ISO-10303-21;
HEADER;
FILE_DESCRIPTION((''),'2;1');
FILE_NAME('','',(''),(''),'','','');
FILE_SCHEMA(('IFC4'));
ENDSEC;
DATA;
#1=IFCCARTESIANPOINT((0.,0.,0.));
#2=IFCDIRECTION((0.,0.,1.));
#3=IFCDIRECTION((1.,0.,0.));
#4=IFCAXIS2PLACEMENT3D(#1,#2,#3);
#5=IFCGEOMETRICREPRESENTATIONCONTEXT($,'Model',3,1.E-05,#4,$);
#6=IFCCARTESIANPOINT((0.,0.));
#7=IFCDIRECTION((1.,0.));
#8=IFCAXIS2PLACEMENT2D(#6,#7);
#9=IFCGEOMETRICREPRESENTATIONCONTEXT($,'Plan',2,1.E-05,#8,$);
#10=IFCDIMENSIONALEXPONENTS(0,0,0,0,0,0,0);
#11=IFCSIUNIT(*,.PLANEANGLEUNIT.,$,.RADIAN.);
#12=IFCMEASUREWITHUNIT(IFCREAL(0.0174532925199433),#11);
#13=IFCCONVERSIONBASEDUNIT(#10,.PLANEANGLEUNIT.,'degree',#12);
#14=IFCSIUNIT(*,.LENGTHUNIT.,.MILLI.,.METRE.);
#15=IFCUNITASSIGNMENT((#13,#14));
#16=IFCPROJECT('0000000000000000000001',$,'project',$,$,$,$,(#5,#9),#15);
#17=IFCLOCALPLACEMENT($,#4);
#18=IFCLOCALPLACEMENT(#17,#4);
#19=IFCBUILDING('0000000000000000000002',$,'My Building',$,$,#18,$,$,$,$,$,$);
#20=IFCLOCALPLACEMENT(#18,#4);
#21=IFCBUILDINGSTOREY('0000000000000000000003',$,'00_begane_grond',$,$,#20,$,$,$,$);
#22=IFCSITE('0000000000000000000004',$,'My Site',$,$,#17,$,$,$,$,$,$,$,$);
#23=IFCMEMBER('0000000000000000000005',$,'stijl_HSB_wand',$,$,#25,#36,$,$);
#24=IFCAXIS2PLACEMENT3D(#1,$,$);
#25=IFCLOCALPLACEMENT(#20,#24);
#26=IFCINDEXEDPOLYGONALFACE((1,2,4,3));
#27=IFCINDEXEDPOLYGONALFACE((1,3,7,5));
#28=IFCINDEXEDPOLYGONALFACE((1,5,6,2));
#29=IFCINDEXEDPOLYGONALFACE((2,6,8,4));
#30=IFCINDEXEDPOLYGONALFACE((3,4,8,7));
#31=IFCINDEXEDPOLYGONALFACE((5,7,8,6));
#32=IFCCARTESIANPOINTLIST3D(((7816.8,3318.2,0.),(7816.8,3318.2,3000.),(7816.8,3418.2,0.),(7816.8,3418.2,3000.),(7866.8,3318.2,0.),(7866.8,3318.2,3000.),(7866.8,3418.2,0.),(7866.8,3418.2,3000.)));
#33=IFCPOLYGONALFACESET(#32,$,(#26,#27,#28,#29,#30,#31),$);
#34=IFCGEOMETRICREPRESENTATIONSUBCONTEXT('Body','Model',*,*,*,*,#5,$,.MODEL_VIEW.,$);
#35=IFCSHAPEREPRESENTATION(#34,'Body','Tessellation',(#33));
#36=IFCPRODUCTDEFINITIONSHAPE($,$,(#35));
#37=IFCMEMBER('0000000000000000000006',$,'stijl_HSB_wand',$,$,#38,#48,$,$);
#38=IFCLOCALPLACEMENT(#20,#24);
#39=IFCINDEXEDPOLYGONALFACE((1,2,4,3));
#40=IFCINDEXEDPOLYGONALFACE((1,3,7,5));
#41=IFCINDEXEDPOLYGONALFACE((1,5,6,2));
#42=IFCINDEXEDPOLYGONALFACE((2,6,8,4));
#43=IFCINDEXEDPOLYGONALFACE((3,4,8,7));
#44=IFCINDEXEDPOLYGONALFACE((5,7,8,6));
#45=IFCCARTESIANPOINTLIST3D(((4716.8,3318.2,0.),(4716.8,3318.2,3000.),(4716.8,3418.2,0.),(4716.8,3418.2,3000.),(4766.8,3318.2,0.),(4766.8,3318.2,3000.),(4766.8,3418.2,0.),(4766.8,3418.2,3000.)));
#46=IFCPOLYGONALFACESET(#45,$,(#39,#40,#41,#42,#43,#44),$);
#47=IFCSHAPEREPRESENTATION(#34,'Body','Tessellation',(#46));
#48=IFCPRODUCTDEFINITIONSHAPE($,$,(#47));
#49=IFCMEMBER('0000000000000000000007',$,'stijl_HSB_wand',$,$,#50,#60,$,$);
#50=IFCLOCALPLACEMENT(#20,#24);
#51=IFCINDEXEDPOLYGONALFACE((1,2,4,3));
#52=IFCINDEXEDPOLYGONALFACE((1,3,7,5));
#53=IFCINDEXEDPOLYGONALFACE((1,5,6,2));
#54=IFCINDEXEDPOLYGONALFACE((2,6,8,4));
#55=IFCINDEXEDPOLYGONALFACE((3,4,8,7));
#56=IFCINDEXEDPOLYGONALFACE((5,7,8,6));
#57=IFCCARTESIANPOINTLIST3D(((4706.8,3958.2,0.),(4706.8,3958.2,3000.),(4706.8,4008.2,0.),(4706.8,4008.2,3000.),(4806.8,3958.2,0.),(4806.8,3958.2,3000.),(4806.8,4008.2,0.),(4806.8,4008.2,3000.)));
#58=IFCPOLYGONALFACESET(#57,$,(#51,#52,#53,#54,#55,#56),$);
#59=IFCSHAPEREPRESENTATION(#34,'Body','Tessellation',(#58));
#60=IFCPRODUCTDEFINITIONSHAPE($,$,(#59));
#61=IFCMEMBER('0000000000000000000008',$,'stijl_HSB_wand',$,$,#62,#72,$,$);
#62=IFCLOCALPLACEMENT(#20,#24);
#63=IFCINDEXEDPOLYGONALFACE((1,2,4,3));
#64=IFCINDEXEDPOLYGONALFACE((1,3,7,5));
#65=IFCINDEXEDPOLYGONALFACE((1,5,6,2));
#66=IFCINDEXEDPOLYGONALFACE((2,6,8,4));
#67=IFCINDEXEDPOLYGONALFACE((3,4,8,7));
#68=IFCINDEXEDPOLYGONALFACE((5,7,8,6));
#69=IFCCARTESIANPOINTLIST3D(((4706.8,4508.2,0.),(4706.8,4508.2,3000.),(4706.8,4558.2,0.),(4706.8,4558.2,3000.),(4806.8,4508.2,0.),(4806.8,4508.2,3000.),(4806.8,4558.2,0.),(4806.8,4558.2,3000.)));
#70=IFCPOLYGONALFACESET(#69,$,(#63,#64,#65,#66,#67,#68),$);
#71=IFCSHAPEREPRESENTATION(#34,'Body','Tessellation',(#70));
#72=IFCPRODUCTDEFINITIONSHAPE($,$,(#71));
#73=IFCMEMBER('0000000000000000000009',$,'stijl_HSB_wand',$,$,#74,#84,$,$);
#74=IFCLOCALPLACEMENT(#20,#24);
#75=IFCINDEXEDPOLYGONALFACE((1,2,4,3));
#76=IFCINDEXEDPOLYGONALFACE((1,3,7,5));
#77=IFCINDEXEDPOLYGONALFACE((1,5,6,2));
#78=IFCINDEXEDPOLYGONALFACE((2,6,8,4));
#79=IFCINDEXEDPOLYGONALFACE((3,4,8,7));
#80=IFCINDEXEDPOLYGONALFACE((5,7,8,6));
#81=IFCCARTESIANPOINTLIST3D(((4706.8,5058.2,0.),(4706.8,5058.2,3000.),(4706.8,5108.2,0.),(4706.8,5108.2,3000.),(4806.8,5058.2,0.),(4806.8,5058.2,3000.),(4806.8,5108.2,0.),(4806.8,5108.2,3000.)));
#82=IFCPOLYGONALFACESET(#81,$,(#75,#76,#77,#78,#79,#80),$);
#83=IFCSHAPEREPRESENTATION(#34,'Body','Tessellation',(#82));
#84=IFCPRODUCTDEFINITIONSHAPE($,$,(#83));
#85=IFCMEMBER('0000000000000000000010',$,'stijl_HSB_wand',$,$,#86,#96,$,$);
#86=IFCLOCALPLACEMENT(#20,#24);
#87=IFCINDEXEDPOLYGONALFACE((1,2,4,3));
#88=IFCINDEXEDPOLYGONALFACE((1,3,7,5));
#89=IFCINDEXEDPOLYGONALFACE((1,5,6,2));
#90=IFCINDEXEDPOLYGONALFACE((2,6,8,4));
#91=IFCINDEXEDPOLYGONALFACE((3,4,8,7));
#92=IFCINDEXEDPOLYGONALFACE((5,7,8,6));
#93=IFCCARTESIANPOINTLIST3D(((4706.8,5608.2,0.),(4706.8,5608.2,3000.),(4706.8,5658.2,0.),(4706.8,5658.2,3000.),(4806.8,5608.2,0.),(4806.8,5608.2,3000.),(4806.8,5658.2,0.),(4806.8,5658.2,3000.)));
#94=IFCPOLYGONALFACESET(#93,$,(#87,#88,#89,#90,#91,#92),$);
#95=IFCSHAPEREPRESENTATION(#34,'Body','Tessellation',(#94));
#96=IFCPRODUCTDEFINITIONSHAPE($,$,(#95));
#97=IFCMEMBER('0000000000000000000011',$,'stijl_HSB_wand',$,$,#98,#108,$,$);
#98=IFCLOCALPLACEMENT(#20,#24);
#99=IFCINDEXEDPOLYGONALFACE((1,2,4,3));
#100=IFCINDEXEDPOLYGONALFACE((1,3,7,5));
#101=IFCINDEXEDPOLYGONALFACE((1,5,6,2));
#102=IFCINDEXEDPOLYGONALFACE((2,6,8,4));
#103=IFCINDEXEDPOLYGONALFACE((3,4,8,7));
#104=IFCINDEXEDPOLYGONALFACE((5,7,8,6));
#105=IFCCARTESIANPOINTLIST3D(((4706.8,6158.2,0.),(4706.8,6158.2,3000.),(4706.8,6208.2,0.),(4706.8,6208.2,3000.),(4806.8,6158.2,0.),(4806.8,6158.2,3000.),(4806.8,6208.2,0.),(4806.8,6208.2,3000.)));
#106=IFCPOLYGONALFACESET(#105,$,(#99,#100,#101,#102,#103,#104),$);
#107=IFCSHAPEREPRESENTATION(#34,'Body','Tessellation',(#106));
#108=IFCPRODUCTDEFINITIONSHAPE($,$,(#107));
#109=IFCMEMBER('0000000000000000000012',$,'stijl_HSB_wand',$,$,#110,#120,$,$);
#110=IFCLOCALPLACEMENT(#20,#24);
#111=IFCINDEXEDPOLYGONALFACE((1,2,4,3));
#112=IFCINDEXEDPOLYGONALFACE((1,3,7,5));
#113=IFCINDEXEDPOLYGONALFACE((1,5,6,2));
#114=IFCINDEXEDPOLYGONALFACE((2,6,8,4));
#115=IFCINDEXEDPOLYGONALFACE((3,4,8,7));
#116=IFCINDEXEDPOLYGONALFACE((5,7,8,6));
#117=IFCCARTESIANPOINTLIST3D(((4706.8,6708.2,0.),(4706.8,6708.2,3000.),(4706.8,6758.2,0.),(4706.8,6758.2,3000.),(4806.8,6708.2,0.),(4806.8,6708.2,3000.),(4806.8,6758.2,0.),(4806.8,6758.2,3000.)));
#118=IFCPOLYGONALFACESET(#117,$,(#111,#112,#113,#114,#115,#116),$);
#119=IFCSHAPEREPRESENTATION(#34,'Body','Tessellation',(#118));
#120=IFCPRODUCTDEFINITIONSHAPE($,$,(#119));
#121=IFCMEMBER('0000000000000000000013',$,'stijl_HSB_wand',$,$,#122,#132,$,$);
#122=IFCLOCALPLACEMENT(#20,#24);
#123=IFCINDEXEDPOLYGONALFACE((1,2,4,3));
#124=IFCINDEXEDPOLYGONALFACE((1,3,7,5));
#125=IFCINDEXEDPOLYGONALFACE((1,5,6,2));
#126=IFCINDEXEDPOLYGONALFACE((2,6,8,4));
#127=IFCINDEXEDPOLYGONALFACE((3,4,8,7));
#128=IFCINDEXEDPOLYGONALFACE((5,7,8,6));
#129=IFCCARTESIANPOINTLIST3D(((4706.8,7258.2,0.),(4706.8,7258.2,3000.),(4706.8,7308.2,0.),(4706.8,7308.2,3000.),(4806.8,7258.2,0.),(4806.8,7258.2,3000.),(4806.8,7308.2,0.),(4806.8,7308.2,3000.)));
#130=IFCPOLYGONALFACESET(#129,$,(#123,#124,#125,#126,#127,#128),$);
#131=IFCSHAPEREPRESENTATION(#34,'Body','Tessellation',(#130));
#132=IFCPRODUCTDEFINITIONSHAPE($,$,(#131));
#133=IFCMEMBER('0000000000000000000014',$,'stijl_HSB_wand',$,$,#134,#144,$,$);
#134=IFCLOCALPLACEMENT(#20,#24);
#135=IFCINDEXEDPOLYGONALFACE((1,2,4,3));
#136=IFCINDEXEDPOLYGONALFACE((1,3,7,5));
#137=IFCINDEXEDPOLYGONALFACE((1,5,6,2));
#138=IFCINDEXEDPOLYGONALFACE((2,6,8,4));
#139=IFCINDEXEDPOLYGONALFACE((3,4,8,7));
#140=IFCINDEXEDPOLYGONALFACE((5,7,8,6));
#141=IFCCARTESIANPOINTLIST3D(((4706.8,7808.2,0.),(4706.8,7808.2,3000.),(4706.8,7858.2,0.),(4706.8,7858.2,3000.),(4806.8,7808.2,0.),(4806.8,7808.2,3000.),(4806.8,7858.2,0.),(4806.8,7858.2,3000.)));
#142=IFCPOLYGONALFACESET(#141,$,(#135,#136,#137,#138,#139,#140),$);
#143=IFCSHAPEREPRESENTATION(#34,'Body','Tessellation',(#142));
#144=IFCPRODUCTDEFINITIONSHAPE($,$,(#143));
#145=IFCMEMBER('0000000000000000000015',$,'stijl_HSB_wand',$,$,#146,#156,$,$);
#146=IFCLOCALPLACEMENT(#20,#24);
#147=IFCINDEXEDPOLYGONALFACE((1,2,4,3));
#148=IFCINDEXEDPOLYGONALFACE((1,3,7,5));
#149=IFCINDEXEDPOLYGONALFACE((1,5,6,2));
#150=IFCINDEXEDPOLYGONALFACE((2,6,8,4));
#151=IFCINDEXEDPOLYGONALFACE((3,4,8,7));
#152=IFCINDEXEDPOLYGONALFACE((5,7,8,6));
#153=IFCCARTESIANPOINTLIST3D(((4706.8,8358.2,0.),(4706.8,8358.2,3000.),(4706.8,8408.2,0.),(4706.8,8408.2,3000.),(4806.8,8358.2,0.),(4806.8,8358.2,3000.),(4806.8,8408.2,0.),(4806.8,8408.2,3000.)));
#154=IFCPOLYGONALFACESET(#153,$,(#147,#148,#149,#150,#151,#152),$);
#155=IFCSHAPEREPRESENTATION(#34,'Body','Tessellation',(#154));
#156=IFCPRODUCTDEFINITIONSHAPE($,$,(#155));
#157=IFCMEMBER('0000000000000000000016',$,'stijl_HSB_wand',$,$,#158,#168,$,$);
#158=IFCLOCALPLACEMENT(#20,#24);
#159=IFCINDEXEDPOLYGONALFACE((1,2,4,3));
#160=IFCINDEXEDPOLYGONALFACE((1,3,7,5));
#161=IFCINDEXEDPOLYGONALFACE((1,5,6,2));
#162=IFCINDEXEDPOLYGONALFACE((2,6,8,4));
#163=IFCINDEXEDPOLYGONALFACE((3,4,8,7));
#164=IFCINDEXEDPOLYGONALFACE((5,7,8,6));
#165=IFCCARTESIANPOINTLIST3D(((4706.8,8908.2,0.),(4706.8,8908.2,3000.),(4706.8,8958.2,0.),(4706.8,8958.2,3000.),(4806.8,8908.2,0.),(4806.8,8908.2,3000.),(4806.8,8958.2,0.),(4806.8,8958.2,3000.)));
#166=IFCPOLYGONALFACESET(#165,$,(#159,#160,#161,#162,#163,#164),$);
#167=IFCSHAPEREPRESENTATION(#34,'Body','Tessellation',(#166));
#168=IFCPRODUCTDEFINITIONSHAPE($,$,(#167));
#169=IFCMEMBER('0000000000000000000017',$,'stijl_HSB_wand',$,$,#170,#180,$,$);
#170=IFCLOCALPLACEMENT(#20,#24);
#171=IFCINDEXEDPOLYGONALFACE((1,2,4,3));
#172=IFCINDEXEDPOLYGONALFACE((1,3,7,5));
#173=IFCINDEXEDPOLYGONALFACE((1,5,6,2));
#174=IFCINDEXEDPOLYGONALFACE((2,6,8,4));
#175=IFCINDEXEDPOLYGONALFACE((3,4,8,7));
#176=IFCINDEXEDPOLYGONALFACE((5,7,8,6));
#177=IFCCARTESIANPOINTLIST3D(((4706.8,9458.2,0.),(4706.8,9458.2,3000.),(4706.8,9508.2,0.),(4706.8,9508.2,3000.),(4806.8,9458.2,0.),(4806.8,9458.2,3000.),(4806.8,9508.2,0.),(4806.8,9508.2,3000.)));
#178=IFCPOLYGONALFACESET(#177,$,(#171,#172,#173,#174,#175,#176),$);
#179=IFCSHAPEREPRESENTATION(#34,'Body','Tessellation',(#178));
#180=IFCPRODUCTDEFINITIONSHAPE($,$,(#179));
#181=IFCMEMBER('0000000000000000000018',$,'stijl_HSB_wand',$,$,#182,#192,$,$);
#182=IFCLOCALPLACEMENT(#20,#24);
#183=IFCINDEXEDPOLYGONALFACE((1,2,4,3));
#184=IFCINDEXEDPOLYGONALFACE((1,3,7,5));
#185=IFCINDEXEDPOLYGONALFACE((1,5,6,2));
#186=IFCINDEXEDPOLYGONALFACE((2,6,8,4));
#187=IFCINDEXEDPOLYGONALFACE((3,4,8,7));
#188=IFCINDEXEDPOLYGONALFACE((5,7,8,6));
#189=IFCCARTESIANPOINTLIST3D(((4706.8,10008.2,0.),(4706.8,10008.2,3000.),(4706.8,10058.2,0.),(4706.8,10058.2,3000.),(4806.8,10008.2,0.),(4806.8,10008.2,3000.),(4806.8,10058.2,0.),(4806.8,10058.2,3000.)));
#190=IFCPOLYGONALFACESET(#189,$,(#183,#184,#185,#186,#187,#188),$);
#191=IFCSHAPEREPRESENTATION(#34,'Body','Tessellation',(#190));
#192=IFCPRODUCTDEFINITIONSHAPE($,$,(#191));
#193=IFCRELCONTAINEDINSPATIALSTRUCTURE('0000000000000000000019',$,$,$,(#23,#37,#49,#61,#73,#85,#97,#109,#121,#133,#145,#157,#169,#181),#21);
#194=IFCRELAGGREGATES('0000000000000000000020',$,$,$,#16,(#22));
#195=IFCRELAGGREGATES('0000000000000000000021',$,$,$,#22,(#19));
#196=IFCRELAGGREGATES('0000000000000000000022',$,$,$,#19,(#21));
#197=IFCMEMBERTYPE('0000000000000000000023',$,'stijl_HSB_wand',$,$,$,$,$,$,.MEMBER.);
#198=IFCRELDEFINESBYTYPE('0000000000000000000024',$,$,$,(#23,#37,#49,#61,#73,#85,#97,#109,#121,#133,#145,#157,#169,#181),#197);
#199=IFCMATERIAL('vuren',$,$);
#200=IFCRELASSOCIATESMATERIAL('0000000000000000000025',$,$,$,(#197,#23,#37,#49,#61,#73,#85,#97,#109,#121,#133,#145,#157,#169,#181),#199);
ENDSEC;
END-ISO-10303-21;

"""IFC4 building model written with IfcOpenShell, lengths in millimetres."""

from ifc_helpers import new_model, entity, si_unit, converted_unit, frame, origin_with_axes, origin_2d_with_axis, place, context, subcontext, project, spatial, rectangle, extrude, material, material_profile, profile_set, profile_usage, type_object, element, save


model = new_model("IFC4")

# Units and contexts
model_context = context("Model", 3, precision=1e-05, world=origin_with_axes())
plan_context = context("Plan", 2, precision=1e-05, world=origin_2d_with_axis())
body_context = subcontext(model_context, "Body", "Model", "MODEL_VIEW")
ifc_project = project(units=[converted_unit("PLANEANGLEUNIT", "degree", entity("IfcReal", 0.0174532925199433), si_unit("PLANEANGLEUNIT", "RADIAN"), dimensions=[0, 0, 0, 0, 0, 0, 0]), si_unit("LENGTHUNIT", "METRE", prefix="MILLI")], contexts=[model_context, plan_context])

# Site, building, storey
site_placement = place(None, origin_with_axes())
site = spatial("IfcSite", under=ifc_project, at=site_placement, Name="My Site")
building_placement = place(site_placement, origin_with_axes())
building = spatial("IfcBuilding", under=site, at=building_placement, Name="My Building")
storey_placement = place(building_placement, origin_with_axes())
storey = spatial("IfcBuildingStorey", under=building, at=storey_placement, Name="00_begane_grond")

# Members
ifc_material_1 = material(Name="vuren")
ifc_material_profile_1 = material_profile(ifc_material_1, rectangle(XDim=100.0, YDim=50.0))
ifc_material_profile_2 = material_profile(ifc_material_1, rectangle(XDim=100.0, YDim=50.0))
ifc_profile_set_1 = profile_set([ifc_material_profile_1, ifc_material_profile_2])
ifc_profile_usage_1 = profile_usage(ifc_profile_set_1, cardinal=1)
member_type_1 = type_object("IfcMemberType", Name="stijl_HSB_wand", PredefinedType="MEMBER", material=ifc_profile_set_1)
member_1_placement = place(storey_placement, frame((7866.8, 3418.2, 0.0), z_axis=(0.0, 0.0, 1.0), x_axis=(0.0, 1.0, 0.0)))
element("IfcMember", 1, at=member_1_placement, inside=storey, type_object=member_type_1, material=ifc_profile_usage_1, Name="stijl_HSB_wand", context=body_context, shape_type="SweptSolid", body=[
    extrude(rectangle(XDim=100.0, YDim=50.0), frame((-50.0, 25.0, 0.0), z_axis=(0.0, 0.0, 1.0), x_axis=(1.0, 0.0, 0.0)), (0.0, 0.0, 1.0), 3000.0),
])
ifc_profile_usage_2 = profile_usage(ifc_profile_set_1, cardinal=1)
member_2_placement = place(storey_placement, frame((4766.8, 3418.2, 0.0), z_axis=(0.0, 0.0, 1.0), x_axis=(0.0, 1.0, 0.0)))
element("IfcMember", 2, at=member_2_placement, inside=storey, type_object=member_type_1, material=ifc_profile_usage_2, Name="stijl_HSB_wand", context=body_context, shape_type="SweptSolid", body=[
    extrude(rectangle(XDim=100.0, YDim=50.0), frame((-50.0, 25.0, 0.0), z_axis=(0.0, 0.0, 1.0), x_axis=(1.0, 0.0, 0.0)), (0.0, 0.0, 1.0), 3000.0),
])
ifc_profile_usage_3 = profile_usage(ifc_profile_set_1, cardinal=1)
member_3_placement = place(storey_placement, frame((4806.8, 3958.2, 0.0), z_axis=(0.0, 0.0, 1.0), x_axis=(1.0, 0.0, 0.0)))
element("IfcMember", 3, at=member_3_placement, inside=storey, type_object=member_type_1, material=ifc_profile_usage_3, Name="stijl_HSB_wand", context=body_context, shape_type="SweptSolid", body=[
    extrude(rectangle(XDim=100.0, YDim=50.0), frame((-50.0, 25.0, 0.0), z_axis=(0.0, 0.0, 1.0), x_axis=(1.0, 0.0, 0.0)), (0.0, 0.0, 1.0), 3000.0),
])
ifc_profile_usage_4 = profile_usage(ifc_profile_set_1, cardinal=1)
member_4_placement = place(storey_placement, frame((4806.8, 4508.2, 0.0), z_axis=(0.0, 0.0, 1.0), x_axis=(1.0, 0.0, 0.0)))
element("IfcMember", 4, at=member_4_placement, inside=storey, type_object=member_type_1, material=ifc_profile_usage_4, Name="stijl_HSB_wand", context=body_context, shape_type="SweptSolid", body=[
    extrude(rectangle(XDim=100.0, YDim=50.0), frame((-50.0, 25.0, 0.0), z_axis=(0.0, 0.0, 1.0), x_axis=(1.0, 0.0, 0.0)), (0.0, 0.0, 1.0), 3000.0),
])
ifc_profile_usage_5 = profile_usage(ifc_profile_set_1, cardinal=1)
member_5_placement = place(storey_placement, frame((4806.8, 5058.2, 0.0), z_axis=(0.0, 0.0, 1.0), x_axis=(1.0, 0.0, 0.0)))
element("IfcMember", 5, at=member_5_placement, inside=storey, type_object=member_type_1, material=ifc_profile_usage_5, Name="stijl_HSB_wand", context=body_context, shape_type="SweptSolid", body=[
    extrude(rectangle(XDim=100.0, YDim=50.0), frame((-50.0, 25.0, 0.0), z_axis=(0.0, 0.0, 1.0), x_axis=(1.0, 0.0, 0.0)), (0.0, 0.0, 1.0), 3000.0),
])
ifc_profile_usage_6 = profile_usage(ifc_profile_set_1, cardinal=1)
member_6_placement = place(storey_placement, frame((4806.8, 5608.2, 0.0), z_axis=(0.0, 0.0, 1.0), x_axis=(1.0, 0.0, 0.0)))
element("IfcMember", 6, at=member_6_placement, inside=storey, type_object=member_type_1, material=ifc_profile_usage_6, Name="stijl_HSB_wand", context=body_context, shape_type="SweptSolid", body=[
    extrude(rectangle(XDim=100.0, YDim=50.0), frame((-50.0, 25.0, 0.0), z_axis=(0.0, 0.0, 1.0), x_axis=(1.0, 0.0, 0.0)), (0.0, 0.0, 1.0), 3000.0),
])
ifc_profile_usage_7 = profile_usage(ifc_profile_set_1, cardinal=1)
member_7_placement = place(storey_placement, frame((4806.8, 6158.2, 0.0), z_axis=(0.0, 0.0, 1.0), x_axis=(1.0, 0.0, 0.0)))
element("IfcMember", 7, at=member_7_placement, inside=storey, type_object=member_type_1, material=ifc_profile_usage_7, Name="stijl_HSB_wand", context=body_context, shape_type="SweptSolid", body=[
    extrude(rectangle(XDim=100.0, YDim=50.0), frame((-50.0, 25.0, 0.0), z_axis=(0.0, 0.0, 1.0), x_axis=(1.0, 0.0, 0.0)), (0.0, 0.0, 1.0), 3000.0),
])
ifc_profile_usage_8 = profile_usage(ifc_profile_set_1, cardinal=1)
member_8_placement = place(storey_placement, frame((4806.8, 6708.2, 0.0), z_axis=(0.0, 0.0, 1.0), x_axis=(1.0, 0.0, 0.0)))
element("IfcMember", 8, at=member_8_placement, inside=storey, type_object=member_type_1, material=ifc_profile_usage_8, Name="stijl_HSB_wand", context=body_context, shape_type="SweptSolid", body=[
    extrude(rectangle(XDim=100.0, YDim=50.0), frame((-50.0, 25.0, 0.0), z_axis=(0.0, 0.0, 1.0), x_axis=(1.0, 0.0, 0.0)), (0.0, 0.0, 1.0), 3000.0),
])
ifc_profile_usage_9 = profile_usage(ifc_profile_set_1, cardinal=1)
member_9_placement = place(storey_placement, frame((4806.8, 7258.2, 0.0), z_axis=(0.0, 0.0, 1.0), x_axis=(1.0, 0.0, 0.0)))
element("IfcMember", 9, at=member_9_placement, inside=storey, type_object=member_type_1, material=ifc_profile_usage_9, Name="stijl_HSB_wand", context=body_context, shape_type="SweptSolid", body=[
    extrude(rectangle(XDim=100.0, YDim=50.0), frame((-50.0, 25.0, 0.0), z_axis=(0.0, 0.0, 1.0), x_axis=(1.0, 0.0, 0.0)), (0.0, 0.0, 1.0), 3000.0),
])
ifc_profile_usage_10 = profile_usage(ifc_profile_set_1, cardinal=1)
member_10_placement = place(storey_placement, frame((4806.8, 7808.2, 0.0), z_axis=(0.0, 0.0, 1.0), x_axis=(1.0, 0.0, 0.0)))
element("IfcMember", 10, at=member_10_placement, inside=storey, type_object=member_type_1, material=ifc_profile_usage_10, Name="stijl_HSB_wand", context=body_context, shape_type="SweptSolid", body=[
    extrude(rectangle(XDim=100.0, YDim=50.0), frame((-50.0, 25.0, 0.0), z_axis=(0.0, 0.0, 1.0), x_axis=(1.0, 0.0, 0.0)), (0.0, 0.0, 1.0), 3000.0),
])
ifc_profile_usage_11 = profile_usage(ifc_profile_set_1, cardinal=1)
member_11_placement = place(storey_placement, frame((4806.8, 8358.2, 0.0), z_axis=(0.0, 0.0, 1.0), x_axis=(1.0, 0.0, 0.0)))
element("IfcMember", 11, at=member_11_placement, inside=storey, type_object=member_type_1, material=ifc_profile_usage_11, Name="stijl_HSB_wand", context=body_context, shape_type="SweptSolid", body=[
    extrude(rectangle(XDim=100.0, YDim=50.0), frame((-50.0, 25.0, 0.0), z_axis=(0.0, 0.0, 1.0), x_axis=(1.0, 0.0, 0.0)), (0.0, 0.0, 1.0), 3000.0),
])
ifc_profile_usage_12 = profile_usage(ifc_profile_set_1, cardinal=1)
member_12_placement = place(storey_placement, frame((4806.8, 8908.2, 0.0), z_axis=(0.0, 0.0, 1.0), x_axis=(1.0, 0.0, 0.0)))
element("IfcMember", 12, at=member_12_placement, inside=storey, type_object=member_type_1, material=ifc_profile_usage_12, Name="stijl_HSB_wand", context=body_context, shape_type="SweptSolid", body=[
    extrude(rectangle(XDim=100.0, YDim=50.0), frame((-50.0, 25.0, 0.0), z_axis=(0.0, 0.0, 1.0), x_axis=(1.0, 0.0, 0.0)), (0.0, 0.0, 1.0), 3000.0),
])
ifc_profile_usage_13 = profile_usage(ifc_profile_set_1, cardinal=1)
member_13_placement = place(storey_placement, frame((4806.8, 9458.2, 0.0), z_axis=(0.0, 0.0, 1.0), x_axis=(1.0, 0.0, 0.0)))
element("IfcMember", 13, at=member_13_placement, inside=storey, type_object=member_type_1, material=ifc_profile_usage_13, Name="stijl_HSB_wand", context=body_context, shape_type="SweptSolid", body=[
    extrude(rectangle(XDim=100.0, YDim=50.0), frame((-50.0, 25.0, 0.0), z_axis=(0.0, 0.0, 1.0), x_axis=(1.0, 0.0, 0.0)), (0.0, 0.0, 1.0), 3000.0),
])
ifc_profile_usage_14 = profile_usage(ifc_profile_set_1, cardinal=1)
member_14_placement = place(storey_placement, frame((4806.8, 10008.2, 0.0), z_axis=(0.0, 0.0, 1.0), x_axis=(1.0, 0.0, 0.0)))
element("IfcMember", 14, at=member_14_placement, inside=storey, type_object=member_type_1, material=ifc_profile_usage_14, Name="stijl_HSB_wand", context=body_context, shape_type="SweptSolid", body=[
    extrude(rectangle(XDim=100.0, YDim=50.0), frame((-50.0, 25.0, 0.0), z_axis=(0.0, 0.0, 1.0), x_axis=(1.0, 0.0, 0.0)), (0.0, 0.0, 1.0), 3000.0),
])

save(model, "model.ifc")
